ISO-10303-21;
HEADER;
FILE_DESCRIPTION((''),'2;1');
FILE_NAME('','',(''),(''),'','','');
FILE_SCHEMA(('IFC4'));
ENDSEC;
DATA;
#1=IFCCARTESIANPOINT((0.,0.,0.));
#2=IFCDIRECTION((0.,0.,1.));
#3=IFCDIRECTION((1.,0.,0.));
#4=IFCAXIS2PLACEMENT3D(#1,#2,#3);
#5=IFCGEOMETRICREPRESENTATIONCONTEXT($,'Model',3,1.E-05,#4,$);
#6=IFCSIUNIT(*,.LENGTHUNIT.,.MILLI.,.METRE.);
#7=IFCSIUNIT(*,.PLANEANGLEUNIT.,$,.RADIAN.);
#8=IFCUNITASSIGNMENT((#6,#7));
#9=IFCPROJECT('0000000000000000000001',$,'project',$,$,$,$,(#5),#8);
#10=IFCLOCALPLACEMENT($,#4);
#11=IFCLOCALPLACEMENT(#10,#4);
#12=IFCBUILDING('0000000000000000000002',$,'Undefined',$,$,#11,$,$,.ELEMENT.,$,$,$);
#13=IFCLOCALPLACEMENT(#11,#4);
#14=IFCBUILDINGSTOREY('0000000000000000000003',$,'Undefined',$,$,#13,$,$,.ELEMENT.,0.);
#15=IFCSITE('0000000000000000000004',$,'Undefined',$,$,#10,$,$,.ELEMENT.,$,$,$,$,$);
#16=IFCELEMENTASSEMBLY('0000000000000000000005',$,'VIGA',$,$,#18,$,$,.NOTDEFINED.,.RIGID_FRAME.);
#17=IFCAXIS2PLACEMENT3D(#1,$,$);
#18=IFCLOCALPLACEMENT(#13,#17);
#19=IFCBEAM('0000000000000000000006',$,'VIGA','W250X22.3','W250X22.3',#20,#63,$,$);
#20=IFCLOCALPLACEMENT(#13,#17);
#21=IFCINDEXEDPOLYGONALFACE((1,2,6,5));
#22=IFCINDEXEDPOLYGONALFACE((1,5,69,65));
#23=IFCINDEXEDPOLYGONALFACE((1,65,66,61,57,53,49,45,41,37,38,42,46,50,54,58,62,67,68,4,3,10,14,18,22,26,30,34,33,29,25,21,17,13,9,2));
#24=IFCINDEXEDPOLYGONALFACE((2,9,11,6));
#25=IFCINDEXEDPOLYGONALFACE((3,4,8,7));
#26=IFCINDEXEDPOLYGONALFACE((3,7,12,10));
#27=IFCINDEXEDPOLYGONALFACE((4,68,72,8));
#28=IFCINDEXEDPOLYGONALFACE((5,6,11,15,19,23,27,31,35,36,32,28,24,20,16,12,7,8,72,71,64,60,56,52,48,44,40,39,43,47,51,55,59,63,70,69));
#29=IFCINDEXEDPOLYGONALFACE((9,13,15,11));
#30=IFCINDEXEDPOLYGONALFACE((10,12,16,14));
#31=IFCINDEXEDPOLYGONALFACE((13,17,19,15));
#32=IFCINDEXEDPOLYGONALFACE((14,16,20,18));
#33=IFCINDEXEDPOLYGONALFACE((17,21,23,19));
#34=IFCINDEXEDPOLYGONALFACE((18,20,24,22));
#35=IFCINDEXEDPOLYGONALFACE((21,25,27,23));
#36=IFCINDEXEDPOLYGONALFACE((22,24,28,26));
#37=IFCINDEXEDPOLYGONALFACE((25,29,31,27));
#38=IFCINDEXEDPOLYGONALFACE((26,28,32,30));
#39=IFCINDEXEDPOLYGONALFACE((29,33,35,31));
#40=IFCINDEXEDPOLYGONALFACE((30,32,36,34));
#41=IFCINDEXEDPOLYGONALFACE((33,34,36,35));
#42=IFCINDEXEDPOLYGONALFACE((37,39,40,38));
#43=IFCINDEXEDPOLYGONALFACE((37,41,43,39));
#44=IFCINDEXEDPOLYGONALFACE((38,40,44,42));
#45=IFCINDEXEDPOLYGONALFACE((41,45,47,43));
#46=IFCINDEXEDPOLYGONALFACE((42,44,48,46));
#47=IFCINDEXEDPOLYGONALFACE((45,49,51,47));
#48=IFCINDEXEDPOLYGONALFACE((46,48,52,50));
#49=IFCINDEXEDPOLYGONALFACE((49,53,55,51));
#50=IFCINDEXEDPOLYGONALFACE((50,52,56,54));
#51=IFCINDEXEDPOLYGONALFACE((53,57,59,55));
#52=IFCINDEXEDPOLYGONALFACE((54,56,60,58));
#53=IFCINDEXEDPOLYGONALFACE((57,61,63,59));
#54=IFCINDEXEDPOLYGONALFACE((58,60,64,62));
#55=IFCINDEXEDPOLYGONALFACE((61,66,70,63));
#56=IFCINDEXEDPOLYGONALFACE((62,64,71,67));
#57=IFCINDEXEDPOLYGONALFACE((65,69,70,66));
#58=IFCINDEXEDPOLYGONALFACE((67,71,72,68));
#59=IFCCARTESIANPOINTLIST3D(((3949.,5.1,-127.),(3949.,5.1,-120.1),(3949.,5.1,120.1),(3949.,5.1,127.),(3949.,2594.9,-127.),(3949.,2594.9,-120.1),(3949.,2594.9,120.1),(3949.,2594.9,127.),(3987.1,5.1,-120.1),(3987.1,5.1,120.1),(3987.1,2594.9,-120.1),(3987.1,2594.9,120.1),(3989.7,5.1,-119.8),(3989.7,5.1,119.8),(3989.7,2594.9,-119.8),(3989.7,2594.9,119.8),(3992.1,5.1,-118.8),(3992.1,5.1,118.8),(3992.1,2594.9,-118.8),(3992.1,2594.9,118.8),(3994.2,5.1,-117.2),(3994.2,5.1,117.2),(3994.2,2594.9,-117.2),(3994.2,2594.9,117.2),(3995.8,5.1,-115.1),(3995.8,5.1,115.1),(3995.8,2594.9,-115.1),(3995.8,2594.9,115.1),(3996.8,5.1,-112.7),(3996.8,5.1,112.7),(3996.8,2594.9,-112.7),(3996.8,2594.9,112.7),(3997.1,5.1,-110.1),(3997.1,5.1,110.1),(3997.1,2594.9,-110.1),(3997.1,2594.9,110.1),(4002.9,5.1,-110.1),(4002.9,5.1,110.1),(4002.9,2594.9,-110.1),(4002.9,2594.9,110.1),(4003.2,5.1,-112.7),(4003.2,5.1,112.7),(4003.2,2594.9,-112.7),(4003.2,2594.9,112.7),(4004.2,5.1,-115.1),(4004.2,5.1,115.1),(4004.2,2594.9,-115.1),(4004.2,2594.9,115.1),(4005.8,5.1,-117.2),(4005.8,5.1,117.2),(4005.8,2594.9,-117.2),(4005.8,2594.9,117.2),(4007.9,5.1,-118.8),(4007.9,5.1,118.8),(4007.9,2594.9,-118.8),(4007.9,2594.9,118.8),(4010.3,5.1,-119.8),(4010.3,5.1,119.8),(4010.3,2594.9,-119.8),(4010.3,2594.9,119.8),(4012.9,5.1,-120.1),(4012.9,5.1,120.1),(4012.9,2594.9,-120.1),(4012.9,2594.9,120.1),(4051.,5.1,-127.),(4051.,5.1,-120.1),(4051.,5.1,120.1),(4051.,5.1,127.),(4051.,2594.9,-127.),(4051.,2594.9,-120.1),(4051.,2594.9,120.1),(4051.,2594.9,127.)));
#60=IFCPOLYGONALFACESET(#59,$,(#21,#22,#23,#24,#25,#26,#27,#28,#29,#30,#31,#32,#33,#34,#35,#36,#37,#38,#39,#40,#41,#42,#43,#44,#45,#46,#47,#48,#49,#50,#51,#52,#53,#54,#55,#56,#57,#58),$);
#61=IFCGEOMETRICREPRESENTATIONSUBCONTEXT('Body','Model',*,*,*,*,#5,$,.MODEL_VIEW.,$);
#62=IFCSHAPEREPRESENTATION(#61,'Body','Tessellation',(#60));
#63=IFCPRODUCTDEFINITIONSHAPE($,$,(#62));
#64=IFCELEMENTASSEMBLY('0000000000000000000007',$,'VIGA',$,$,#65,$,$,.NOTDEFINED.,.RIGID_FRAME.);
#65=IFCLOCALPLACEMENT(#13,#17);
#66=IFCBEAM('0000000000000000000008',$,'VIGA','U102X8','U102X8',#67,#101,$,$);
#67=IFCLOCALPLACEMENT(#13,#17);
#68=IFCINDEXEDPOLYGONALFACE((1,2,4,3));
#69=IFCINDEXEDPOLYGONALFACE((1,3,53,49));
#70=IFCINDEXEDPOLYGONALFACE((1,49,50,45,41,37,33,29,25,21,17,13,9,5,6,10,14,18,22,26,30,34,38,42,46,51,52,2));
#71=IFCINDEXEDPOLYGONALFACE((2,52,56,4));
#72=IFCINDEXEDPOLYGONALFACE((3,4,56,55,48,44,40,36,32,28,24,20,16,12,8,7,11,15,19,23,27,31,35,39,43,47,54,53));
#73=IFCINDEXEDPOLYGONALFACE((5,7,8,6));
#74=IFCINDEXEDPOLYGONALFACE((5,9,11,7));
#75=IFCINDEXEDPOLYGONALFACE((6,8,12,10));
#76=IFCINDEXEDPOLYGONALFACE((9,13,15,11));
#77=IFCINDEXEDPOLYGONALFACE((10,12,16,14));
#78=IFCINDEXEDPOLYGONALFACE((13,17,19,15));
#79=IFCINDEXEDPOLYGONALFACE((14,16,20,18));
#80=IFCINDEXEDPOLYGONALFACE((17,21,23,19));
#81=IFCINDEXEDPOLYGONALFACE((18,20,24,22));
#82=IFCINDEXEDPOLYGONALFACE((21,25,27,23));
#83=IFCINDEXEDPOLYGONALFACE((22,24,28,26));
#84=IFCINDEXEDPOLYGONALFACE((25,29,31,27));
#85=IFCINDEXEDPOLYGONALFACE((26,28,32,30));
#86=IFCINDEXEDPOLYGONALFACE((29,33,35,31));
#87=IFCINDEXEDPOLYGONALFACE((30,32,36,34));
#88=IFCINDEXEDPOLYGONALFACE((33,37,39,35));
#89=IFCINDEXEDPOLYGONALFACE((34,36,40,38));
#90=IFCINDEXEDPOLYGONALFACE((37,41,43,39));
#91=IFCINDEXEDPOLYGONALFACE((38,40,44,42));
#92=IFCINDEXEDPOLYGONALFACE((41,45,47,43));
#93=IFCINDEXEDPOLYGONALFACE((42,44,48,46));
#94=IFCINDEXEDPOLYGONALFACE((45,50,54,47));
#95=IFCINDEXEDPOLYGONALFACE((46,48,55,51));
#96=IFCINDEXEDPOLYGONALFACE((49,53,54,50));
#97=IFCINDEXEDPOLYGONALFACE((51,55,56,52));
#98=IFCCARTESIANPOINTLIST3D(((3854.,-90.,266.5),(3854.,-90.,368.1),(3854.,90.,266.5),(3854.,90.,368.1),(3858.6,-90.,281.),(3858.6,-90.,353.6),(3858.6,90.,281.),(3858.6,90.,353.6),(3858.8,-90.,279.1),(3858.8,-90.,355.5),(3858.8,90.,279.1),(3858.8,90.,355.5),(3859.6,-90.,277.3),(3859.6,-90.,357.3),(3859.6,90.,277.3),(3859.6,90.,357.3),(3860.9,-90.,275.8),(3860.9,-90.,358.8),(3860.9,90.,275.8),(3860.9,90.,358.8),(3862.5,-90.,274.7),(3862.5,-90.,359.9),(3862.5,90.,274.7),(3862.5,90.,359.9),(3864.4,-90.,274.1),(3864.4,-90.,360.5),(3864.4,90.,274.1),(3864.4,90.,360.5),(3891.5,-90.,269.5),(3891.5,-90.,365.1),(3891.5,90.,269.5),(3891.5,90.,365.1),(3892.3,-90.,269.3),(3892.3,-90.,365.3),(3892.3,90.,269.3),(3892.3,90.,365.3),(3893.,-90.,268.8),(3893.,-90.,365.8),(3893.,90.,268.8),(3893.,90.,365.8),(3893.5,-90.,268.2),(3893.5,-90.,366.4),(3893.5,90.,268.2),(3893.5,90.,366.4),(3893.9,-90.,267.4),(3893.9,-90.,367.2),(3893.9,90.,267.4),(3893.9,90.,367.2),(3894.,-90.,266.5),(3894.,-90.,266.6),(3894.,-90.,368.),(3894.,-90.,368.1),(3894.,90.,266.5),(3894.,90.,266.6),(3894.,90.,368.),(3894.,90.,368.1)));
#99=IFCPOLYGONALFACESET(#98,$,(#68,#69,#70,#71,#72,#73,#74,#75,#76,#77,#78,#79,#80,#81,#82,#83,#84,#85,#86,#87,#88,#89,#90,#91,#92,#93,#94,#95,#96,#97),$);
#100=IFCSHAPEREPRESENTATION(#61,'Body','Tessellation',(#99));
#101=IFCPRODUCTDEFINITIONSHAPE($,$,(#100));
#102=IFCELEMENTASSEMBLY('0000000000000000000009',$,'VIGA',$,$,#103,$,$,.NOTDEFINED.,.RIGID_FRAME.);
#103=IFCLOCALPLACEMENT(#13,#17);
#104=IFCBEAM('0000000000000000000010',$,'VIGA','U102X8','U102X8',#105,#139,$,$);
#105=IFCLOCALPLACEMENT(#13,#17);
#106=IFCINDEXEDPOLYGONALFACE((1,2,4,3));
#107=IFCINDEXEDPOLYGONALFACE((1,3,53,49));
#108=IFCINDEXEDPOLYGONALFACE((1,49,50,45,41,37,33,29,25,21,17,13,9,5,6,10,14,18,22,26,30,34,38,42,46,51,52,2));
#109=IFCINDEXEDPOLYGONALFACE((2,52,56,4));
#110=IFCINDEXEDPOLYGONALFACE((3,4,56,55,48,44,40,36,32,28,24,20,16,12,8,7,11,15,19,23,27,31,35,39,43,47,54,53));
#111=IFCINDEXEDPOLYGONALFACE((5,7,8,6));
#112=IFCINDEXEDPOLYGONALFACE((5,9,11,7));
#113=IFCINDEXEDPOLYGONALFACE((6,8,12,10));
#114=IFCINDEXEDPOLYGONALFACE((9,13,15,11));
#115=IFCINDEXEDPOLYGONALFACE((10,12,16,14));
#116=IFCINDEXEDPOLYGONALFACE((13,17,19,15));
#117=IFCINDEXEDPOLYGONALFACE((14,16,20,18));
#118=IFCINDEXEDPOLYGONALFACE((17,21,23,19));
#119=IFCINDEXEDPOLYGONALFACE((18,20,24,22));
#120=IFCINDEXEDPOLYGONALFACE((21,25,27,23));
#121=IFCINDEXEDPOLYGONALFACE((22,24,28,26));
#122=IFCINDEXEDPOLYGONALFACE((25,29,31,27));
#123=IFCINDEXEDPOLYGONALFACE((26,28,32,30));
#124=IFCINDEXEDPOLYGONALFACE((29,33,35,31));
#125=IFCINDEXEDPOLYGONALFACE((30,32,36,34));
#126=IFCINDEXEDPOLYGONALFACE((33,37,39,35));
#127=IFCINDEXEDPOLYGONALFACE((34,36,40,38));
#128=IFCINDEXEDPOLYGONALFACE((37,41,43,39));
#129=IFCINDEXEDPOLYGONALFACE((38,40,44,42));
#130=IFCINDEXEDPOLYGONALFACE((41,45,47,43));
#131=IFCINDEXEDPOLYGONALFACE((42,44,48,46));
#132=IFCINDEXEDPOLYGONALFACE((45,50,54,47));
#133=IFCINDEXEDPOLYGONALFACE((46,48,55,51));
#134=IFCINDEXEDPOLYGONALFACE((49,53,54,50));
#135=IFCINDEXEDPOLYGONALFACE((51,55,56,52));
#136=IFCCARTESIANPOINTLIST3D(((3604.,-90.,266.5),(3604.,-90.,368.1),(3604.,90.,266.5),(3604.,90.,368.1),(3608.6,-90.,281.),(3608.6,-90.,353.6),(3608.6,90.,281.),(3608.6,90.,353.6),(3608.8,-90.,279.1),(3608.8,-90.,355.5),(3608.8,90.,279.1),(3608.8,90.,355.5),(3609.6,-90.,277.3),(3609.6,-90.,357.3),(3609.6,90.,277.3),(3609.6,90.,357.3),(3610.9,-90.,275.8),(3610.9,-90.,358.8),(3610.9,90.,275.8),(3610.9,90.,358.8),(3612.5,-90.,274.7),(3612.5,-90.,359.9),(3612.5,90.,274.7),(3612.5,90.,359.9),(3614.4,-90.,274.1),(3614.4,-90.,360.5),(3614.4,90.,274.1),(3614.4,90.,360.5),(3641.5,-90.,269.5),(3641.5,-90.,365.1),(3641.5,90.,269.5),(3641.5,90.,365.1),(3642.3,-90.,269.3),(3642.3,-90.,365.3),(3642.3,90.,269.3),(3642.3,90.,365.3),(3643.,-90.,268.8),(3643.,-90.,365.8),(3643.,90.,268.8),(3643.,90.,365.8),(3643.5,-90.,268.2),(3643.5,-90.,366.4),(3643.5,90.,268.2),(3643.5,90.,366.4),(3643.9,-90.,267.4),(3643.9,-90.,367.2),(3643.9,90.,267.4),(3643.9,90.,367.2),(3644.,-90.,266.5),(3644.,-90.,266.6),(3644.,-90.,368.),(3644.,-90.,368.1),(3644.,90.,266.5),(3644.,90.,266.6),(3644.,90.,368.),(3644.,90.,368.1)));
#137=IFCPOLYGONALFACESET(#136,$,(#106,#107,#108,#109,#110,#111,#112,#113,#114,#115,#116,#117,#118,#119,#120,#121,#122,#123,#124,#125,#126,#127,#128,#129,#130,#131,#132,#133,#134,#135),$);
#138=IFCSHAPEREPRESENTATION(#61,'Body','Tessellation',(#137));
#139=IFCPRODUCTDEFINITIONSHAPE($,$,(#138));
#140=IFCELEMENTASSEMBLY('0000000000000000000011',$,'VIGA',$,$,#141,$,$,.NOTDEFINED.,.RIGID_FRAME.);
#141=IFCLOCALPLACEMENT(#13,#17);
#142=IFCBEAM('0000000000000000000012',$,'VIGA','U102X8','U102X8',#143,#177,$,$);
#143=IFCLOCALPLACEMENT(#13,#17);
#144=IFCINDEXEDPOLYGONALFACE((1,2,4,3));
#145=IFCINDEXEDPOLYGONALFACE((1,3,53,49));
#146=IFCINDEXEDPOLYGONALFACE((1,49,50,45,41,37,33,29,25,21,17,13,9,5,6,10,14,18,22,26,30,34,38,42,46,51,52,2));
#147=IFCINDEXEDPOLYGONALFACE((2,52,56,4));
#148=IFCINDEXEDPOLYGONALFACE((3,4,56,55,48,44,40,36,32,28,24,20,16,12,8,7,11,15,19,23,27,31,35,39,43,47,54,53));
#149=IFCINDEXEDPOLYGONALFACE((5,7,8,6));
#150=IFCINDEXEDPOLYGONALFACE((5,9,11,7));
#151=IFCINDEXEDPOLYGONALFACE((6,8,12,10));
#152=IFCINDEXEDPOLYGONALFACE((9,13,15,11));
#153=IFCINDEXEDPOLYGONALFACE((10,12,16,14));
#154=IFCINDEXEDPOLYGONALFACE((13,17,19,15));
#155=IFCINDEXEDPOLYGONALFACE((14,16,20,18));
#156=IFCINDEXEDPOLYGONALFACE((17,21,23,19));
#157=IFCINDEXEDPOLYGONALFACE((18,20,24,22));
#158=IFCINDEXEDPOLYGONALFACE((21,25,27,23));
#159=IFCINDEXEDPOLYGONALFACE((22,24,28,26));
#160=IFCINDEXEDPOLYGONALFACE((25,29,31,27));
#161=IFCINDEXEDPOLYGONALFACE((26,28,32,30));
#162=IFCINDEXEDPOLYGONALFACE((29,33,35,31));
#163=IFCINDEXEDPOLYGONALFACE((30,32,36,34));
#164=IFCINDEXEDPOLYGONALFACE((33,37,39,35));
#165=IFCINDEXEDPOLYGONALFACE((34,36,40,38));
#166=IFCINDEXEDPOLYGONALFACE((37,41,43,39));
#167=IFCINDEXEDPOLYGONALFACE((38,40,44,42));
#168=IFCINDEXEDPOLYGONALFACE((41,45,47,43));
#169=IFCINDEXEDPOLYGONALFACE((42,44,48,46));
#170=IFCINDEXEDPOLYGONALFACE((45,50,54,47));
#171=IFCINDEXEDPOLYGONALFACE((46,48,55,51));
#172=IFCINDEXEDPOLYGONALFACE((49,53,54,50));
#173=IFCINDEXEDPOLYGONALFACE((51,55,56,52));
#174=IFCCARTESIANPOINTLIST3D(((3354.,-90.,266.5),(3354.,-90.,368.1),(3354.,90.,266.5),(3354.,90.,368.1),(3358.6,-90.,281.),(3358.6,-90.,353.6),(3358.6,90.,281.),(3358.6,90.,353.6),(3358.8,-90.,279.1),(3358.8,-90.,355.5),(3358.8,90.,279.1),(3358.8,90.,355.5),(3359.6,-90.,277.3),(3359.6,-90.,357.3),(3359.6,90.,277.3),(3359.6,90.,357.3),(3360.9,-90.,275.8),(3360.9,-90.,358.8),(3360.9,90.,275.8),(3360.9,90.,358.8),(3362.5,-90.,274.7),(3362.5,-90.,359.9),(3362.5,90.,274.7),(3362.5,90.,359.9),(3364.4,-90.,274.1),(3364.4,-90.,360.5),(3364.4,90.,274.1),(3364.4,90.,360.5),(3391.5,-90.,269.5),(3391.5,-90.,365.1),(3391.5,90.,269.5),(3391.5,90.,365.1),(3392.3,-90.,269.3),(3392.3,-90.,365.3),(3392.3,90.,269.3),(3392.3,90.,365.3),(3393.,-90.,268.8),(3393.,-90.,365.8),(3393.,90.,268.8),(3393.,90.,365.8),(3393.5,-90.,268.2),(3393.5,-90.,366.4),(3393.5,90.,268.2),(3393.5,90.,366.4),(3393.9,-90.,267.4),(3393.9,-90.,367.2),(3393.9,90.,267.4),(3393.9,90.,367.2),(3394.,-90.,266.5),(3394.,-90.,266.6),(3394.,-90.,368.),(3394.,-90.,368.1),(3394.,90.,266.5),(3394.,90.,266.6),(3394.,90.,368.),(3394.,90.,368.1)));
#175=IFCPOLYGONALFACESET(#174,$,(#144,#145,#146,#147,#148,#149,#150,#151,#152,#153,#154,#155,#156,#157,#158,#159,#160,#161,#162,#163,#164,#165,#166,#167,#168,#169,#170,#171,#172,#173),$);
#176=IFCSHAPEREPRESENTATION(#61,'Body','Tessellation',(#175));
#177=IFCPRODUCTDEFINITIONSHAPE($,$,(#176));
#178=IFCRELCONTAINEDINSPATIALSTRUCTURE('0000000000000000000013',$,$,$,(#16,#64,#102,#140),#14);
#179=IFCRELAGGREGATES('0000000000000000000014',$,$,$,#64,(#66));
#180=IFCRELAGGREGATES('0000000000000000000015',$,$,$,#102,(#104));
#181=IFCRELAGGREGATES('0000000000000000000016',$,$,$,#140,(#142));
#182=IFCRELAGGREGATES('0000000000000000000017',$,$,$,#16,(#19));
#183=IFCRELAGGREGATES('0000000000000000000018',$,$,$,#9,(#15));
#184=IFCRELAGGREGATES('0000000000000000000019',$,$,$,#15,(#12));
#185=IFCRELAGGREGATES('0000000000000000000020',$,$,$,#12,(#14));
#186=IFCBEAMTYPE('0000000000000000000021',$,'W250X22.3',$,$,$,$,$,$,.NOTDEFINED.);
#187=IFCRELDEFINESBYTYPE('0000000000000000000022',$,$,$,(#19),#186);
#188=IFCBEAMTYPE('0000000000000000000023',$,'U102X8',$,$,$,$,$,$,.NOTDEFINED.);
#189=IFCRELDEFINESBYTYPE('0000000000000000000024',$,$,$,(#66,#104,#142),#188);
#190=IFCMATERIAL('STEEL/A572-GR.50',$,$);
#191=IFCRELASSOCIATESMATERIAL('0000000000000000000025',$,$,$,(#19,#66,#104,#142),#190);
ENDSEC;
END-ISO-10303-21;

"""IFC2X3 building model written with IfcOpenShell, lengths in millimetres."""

from ifc_helpers import new_model, si_unit, frame, origin_with_axes, origin_2d_with_axis, place, context, subcontext, project, spatial, i_section, u_section, extrude, material, type_object, element, aggregate, save


model = new_model("IFC2X3")

# Units and contexts
model_context = context("Model", 3, precision=1e-05, world=origin_with_axes())
body_context = subcontext(model_context, "Body", "Model", "MODEL_VIEW")
ifc_project = project(units=[si_unit("LENGTHUNIT", "METRE", prefix="MILLI"), si_unit("PLANEANGLEUNIT", "RADIAN")], contexts=[model_context])

# Site, building, storey
site_placement = place(None, origin_with_axes())
site = spatial("IfcSite", under=ifc_project, at=site_placement, Name="Undefined", CompositionType="ELEMENT")
building_placement = place(site_placement, origin_with_axes())
building = spatial("IfcBuilding", under=site, at=building_placement, Name="Undefined", CompositionType="ELEMENT")
storey_placement = place(building_placement, origin_with_axes())
storey = spatial("IfcBuildingStorey", under=building, at=storey_placement, Name="Undefined", CompositionType="ELEMENT", Elevation=0.0)

# Element assemblies, beams
assembly_1_placement = place(storey_placement, origin_with_axes())
assembly_1 = element("IfcElementAssembly", 1, at=assembly_1_placement, inside=storey, Name="VIGA", AssemblyPlace="NOTDEFINED", PredefinedType="RIGID_FRAME")
ifc_material_1 = material(Name="STEEL/A572-GR.50")
beam_type_1 = type_object("IfcBeamType", Name="W250X22.3", PredefinedType="NOTDEFINED")
beam_1_placement = place(assembly_1_placement, frame((4000.0, 5.1, 0.0), z_axis=(0.0, 0.0, 1.0), x_axis=(0.0, 1.0, 0.0)))
beam_1 = element("IfcBeam", 2, at=beam_1_placement, type_object=beam_type_1, material=ifc_material_1, Name="VIGA", Description="W250X22.3", ObjectType="W250X22.3", context=body_context, shape_type="SweptSolid", body=[
    extrude(i_section(OverallWidth=102.0, OverallDepth=254.0, WebThickness=5.8, FlangeThickness=6.9, FilletRadius=10.0, at=origin_2d_with_axis()), frame((2589.8, 0.0, 0.0), z_axis=(-1.0, 0.0, 0.0), x_axis=(0.0, -1.0, 0.0)), (0.0, 0.0, 1.0), 2589.8),
])
assembly_2_placement = place(storey_placement, origin_with_axes())
assembly_2 = element("IfcElementAssembly", 3, at=assembly_2_placement, inside=storey, Name="VIGA", AssemblyPlace="NOTDEFINED", PredefinedType="RIGID_FRAME")
beam_type_2 = type_object("IfcBeamType", Name="U102X8", PredefinedType="NOTDEFINED")
beam_2_placement = place(assembly_2_placement, frame((3874.0, -90.0, 317.3), z_axis=(0.0, 0.0, 1.0), x_axis=(0.0, 1.0, 0.0)))
beam_2 = element("IfcBeam", 4, at=beam_2_placement, type_object=beam_type_2, material=ifc_material_1, Name="VIGA", Description="U102X8", ObjectType="U102X8", context=body_context, shape_type="SweptSolid", body=[
    extrude(u_section(Depth=101.6, FlangeWidth=40.0, WebThickness=4.6, FlangeThickness=6.0, FilletRadius=7.0, EdgeRadius=3.0, FlangeSlope=0.16839, at=origin_2d_with_axis()), frame((180.0, 0.0, 0.0), z_axis=(-1.0, 0.0, 0.0), x_axis=(0.0, -1.0, 0.0)), (0.0, 0.0, 1.0), 180.0),
])
aggregate(assembly_2, [beam_2])
assembly_3_placement = place(storey_placement, origin_with_axes())
assembly_3 = element("IfcElementAssembly", 5, at=assembly_3_placement, inside=storey, Name="VIGA", AssemblyPlace="NOTDEFINED", PredefinedType="RIGID_FRAME")
beam_3_placement = place(assembly_3_placement, frame((3624.0, -90.0, 317.3), z_axis=(0.0, 0.0, 1.0), x_axis=(0.0, 1.0, 0.0)))
beam_3 = element("IfcBeam", 6, at=beam_3_placement, type_object=beam_type_2, material=ifc_material_1, Name="VIGA", Description="U102X8", ObjectType="U102X8", context=body_context, shape_type="SweptSolid", body=[
    extrude(u_section(Depth=101.6, FlangeWidth=40.0, WebThickness=4.6, FlangeThickness=6.0, FilletRadius=7.0, EdgeRadius=3.0, FlangeSlope=0.16839, at=origin_2d_with_axis()), frame((180.0, 0.0, 0.0), z_axis=(-1.0, 0.0, 0.0), x_axis=(0.0, -1.0, 0.0)), (0.0, 0.0, 1.0), 180.0),
])
aggregate(assembly_3, [beam_3])
assembly_4_placement = place(storey_placement, origin_with_axes())
assembly_4 = element("IfcElementAssembly", 7, at=assembly_4_placement, inside=storey, Name="VIGA", AssemblyPlace="NOTDEFINED", PredefinedType="RIGID_FRAME")
beam_4_placement = place(assembly_4_placement, frame((3374.0, -90.0, 317.3), z_axis=(0.0, 0.0, 1.0), x_axis=(0.0, 1.0, 0.0)))
beam_4 = element("IfcBeam", 8, at=beam_4_placement, type_object=beam_type_2, material=ifc_material_1, Name="VIGA", Description="U102X8", ObjectType="U102X8", context=body_context, shape_type="SweptSolid", body=[
    extrude(u_section(Depth=101.6, FlangeWidth=40.0, WebThickness=4.6, FlangeThickness=6.0, FilletRadius=7.0, EdgeRadius=3.0, FlangeSlope=0.16839, at=origin_2d_with_axis()), frame((180.0, 0.0, 0.0), z_axis=(-1.0, 0.0, 0.0), x_axis=(0.0, -1.0, 0.0)), (0.0, 0.0, 1.0), 180.0),
])
aggregate(assembly_4, [beam_4])

aggregate(assembly_1, [beam_1])

save(model, "model.ifc")
